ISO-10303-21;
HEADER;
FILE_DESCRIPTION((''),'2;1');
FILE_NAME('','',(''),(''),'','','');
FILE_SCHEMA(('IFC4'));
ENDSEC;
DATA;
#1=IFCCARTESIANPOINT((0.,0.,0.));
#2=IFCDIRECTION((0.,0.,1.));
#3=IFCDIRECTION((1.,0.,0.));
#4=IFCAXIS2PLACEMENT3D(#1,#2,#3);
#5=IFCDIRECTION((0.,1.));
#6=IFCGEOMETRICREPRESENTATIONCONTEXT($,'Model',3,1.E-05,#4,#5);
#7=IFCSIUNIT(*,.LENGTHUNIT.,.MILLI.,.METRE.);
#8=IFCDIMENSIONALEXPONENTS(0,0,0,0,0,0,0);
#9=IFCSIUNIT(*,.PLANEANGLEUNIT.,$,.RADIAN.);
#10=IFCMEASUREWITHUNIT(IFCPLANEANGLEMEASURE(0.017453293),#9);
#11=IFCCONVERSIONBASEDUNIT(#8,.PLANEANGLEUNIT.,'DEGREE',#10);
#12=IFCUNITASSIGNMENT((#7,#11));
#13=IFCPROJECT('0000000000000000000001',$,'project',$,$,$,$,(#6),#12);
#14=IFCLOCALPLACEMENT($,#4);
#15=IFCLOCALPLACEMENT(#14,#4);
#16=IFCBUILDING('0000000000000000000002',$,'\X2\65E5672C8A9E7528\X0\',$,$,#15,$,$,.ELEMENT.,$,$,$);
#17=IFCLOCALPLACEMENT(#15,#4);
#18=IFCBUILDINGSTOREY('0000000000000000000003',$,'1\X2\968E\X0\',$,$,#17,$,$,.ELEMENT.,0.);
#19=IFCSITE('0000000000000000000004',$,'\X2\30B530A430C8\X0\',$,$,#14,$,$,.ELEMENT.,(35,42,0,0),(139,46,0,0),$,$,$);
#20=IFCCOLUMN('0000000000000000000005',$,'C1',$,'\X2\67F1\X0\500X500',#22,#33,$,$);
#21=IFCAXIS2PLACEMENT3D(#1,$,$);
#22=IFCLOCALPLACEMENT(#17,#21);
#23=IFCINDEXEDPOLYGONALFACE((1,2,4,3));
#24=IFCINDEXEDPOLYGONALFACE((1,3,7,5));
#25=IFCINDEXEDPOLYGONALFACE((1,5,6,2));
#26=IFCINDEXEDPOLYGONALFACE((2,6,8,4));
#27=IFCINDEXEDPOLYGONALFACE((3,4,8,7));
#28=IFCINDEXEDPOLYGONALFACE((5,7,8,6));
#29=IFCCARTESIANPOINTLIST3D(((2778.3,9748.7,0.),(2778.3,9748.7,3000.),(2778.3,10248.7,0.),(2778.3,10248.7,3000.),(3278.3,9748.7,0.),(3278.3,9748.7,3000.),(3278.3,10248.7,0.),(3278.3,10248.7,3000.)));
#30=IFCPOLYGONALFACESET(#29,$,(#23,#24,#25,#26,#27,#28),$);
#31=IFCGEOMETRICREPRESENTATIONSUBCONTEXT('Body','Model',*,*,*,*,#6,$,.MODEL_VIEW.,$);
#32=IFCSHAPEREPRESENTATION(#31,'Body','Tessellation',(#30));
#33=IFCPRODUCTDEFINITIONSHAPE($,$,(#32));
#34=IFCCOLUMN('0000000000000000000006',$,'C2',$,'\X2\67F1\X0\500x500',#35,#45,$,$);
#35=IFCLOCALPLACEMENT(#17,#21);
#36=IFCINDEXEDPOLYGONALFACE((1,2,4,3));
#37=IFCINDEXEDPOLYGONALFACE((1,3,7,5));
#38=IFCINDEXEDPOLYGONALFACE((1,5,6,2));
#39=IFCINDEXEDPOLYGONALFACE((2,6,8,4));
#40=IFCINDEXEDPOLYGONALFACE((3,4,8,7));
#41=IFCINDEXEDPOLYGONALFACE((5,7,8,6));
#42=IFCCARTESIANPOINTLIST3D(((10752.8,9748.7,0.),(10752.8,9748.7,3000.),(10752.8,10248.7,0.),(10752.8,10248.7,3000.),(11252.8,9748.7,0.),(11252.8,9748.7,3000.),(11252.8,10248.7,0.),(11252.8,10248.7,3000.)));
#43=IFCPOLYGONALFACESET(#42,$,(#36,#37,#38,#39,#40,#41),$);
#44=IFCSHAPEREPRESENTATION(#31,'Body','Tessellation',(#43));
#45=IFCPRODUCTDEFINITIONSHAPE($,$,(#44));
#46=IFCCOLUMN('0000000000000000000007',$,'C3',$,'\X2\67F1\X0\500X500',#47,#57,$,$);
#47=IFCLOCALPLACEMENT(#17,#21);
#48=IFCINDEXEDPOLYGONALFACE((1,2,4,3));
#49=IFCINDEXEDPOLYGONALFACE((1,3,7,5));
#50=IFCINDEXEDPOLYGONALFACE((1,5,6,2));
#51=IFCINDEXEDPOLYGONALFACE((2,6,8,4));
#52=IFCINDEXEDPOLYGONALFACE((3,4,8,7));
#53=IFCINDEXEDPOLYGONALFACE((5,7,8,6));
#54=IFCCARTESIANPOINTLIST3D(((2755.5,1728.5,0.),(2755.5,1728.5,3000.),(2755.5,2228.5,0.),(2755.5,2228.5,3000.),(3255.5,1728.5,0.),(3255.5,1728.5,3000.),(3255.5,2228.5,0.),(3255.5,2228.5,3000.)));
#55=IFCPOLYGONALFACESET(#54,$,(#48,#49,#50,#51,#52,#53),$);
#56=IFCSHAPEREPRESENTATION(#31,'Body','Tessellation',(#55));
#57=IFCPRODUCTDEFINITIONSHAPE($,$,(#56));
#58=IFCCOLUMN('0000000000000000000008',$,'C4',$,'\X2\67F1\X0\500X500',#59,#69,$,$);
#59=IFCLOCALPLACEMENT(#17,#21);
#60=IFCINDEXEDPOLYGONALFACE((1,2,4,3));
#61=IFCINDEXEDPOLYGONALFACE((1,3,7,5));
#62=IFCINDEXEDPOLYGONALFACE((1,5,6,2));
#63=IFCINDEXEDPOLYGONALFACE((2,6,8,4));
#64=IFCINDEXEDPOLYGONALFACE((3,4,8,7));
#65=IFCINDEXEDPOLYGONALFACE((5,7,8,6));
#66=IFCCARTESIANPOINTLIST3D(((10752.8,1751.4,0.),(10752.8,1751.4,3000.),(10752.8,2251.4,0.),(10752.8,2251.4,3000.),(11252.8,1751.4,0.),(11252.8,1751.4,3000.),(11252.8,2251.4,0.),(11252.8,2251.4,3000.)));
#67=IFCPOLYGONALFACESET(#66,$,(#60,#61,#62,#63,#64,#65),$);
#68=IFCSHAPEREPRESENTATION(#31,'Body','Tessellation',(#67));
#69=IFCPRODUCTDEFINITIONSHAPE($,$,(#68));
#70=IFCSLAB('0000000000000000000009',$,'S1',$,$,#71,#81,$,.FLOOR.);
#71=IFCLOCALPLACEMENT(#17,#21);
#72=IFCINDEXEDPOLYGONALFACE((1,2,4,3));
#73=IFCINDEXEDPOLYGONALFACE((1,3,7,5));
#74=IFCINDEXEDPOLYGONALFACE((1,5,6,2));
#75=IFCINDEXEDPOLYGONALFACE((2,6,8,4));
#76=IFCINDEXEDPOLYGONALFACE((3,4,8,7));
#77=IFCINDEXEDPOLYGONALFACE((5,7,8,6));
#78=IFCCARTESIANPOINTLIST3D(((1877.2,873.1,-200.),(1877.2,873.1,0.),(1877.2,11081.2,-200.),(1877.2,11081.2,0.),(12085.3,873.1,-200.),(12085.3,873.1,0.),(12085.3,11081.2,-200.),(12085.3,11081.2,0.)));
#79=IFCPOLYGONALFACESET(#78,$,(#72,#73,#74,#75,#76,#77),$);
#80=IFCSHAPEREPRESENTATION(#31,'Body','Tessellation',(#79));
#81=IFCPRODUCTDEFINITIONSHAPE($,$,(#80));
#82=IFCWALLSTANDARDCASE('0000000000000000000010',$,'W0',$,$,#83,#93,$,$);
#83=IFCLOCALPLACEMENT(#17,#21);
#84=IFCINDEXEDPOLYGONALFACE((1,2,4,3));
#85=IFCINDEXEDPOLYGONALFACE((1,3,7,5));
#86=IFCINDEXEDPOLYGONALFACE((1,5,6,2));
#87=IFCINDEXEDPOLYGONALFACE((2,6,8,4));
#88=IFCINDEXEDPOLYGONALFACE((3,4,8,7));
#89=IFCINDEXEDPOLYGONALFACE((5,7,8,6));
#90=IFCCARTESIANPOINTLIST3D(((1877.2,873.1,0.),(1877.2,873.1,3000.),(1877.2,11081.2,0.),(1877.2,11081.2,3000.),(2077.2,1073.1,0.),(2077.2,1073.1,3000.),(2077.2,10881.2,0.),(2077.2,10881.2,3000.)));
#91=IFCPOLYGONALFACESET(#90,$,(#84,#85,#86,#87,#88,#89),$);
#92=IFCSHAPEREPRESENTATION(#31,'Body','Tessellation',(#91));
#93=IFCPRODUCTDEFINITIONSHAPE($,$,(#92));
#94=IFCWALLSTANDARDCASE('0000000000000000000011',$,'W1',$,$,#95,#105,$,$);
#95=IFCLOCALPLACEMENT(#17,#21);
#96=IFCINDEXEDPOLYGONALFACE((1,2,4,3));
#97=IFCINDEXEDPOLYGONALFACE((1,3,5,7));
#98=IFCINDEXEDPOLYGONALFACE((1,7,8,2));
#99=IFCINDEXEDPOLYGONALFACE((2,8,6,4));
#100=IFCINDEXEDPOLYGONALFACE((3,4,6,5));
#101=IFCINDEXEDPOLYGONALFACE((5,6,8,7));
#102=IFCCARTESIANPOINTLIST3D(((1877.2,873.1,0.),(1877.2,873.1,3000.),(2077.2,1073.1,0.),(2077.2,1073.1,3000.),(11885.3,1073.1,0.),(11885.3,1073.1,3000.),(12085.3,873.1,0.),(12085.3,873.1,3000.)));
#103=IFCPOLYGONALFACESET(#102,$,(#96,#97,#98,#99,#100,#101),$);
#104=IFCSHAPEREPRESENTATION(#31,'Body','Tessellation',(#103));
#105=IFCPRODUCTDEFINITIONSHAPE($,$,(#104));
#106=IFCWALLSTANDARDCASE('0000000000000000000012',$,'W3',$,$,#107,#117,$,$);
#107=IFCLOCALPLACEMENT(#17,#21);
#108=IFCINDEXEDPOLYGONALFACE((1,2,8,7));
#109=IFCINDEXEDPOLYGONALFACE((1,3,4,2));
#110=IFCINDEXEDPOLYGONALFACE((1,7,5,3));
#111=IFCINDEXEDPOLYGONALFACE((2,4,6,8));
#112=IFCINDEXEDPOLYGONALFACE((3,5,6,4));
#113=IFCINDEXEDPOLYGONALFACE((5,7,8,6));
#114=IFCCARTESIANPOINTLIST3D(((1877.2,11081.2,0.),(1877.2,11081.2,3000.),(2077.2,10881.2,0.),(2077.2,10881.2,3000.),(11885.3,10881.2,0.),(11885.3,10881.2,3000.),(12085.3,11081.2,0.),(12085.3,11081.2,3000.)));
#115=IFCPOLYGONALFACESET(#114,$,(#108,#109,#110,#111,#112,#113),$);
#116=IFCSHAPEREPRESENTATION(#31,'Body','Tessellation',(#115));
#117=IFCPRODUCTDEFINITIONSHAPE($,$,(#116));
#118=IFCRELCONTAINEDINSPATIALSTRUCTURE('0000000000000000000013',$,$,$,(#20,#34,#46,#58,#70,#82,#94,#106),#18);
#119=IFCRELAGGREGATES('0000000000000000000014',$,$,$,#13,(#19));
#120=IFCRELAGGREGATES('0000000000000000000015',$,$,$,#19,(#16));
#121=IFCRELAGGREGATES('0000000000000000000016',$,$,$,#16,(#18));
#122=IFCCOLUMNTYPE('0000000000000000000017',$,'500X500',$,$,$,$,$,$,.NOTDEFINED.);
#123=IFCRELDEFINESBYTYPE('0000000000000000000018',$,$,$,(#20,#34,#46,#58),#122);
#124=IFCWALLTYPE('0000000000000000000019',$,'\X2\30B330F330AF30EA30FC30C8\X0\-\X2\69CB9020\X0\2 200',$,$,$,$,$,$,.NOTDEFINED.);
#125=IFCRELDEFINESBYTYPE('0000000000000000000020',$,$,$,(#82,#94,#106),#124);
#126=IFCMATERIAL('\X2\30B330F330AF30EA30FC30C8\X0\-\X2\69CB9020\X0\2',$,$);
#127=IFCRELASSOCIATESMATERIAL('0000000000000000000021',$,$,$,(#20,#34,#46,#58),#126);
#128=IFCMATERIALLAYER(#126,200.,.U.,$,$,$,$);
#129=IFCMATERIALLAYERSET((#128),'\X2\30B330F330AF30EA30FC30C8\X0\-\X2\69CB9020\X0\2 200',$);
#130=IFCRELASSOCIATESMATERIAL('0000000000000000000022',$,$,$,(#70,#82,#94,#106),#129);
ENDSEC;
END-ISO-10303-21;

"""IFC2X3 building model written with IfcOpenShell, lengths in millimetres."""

from ifc_helpers import new_model, entity, si_unit, converted_unit, direction, frame, origin_with_axes, origin_2d_with_axis, place, context, subcontext, project, spatial, polyline, rectangle, outline, extrude, material, layer, layer_set, layer_usage, type_object, element, save


model = new_model("IFC2X3")

# Units and contexts
model_context = context("Model", 3, precision=1e-05, world=origin_with_axes(), true_north=direction((0.0, 1.0)))
body_context = subcontext(model_context, "Body", "Model", "MODEL_VIEW")
ifc_project = project(units=[si_unit("LENGTHUNIT", "METRE", prefix="MILLI"), converted_unit("PLANEANGLEUNIT", "DEGREE", entity("IfcPlaneAngleMeasure", 0.017453293), si_unit("PLANEANGLEUNIT", "RADIAN"), dimensions=[0, 0, 0, 0, 0, 0, 0])], contexts=[model_context])

# Site, building, storey
site_placement = place(None, origin_with_axes())
site = spatial("IfcSite", under=ifc_project, at=site_placement, Name="サイト", CompositionType="ELEMENT", RefLatitude=(35, 42, 0, 0), RefLongitude=(139, 46, 0, 0))
building_placement = place(site_placement, origin_with_axes())
building = spatial("IfcBuilding", under=site, at=building_placement, Name="日本語用", CompositionType="ELEMENT")
storey_placement = place(building_placement, origin_with_axes())
storey = spatial("IfcBuildingStorey", under=building, at=storey_placement, Name="1階", CompositionType="ELEMENT", Elevation=0.0)

# Columns
ifc_material = material(Name="コンクリート-構造2")
column_type = type_object("IfcColumnType", Name="500X500", PredefinedType="NOTDEFINED")
column_1_placement = place(storey_placement, frame((3028.3, 9998.7, 0.0), z_axis=(0.0, 0.0, 1.0), x_axis=(1.0, 0.0, 0.0)))
element("IfcColumn", 1, at=column_1_placement, inside=storey, type_object=column_type, material=ifc_material, Name="C1", ObjectType="柱500X500", context=body_context, shape_type="SweptSolid", body=[
    extrude(rectangle(XDim=500.0, YDim=500.0, at=origin_2d_with_axis()), origin_with_axes(), (0.0, 0.0, 1.0), 3000.0),
])
column_2_placement = place(storey_placement, frame((11002.8, 9998.7, 0.0), z_axis=(0.0, 0.0, 1.0), x_axis=(1.0, 0.0, 0.0)))
element("IfcColumn", 2, at=column_2_placement, inside=storey, type_object=column_type, material=ifc_material, Name="C2", ObjectType="柱500x500", context=body_context, shape_type="SweptSolid", body=[
    extrude(rectangle(XDim=500.0, YDim=500.0, at=origin_2d_with_axis()), origin_with_axes(), (0.0, 0.0, 1.0), 3000.0),
])
for number, where, z_axis, x_axis, name in (
    (3, (3005.5, 1978.5, 0.0), (0.0, 0.0, 1.0), (1.0, 0.0, 0.0), "C3"),
    (4, (11002.8, 2001.4, 0.0), (0.0, 0.0, 1.0), (1.0, 0.0, 0.0), "C4"),
):
    element("IfcColumn", number, at=place(storey_placement, frame(where, z_axis=z_axis, x_axis=x_axis)), inside=storey, type_object=column_type, material=ifc_material, Name=name, ObjectType="柱500X500", context=body_context, shape_type="SweptSolid", body=[
        extrude(rectangle(XDim=500.0, YDim=500.0, at=origin_2d_with_axis()), origin_with_axes(), (0.0, 0.0, 1.0), 3000.0),
    ])

# Slab
ifc_layer = layer(ifc_material, 200.0, ventilated="UNKNOWN")
ifc_layer_set = layer_set([ifc_layer], Name="コンクリート-構造2 200")
ifc_layer_usage_1 = layer_usage(ifc_layer_set, "AXIS3", "NEGATIVE", 200.0)
slab_placement = place(storey_placement, frame((1877.2, 11081.2, -200.0), z_axis=(0.0, 0.0, 1.0), x_axis=(1.0, 0.0, 0.0)))
element("IfcSlab", 5, at=slab_placement, inside=storey, material=ifc_layer_usage_1, Name="S1", PredefinedType="FLOOR", context=body_context, shape_type="SweptSolid", body=[
    extrude(outline(polyline([(0.0, 0.0), (0.0, -10208.1), (10208.1, -10208.1), (10208.1, 0.0), (0.0, 0.0)])), origin_with_axes(), (0.0, 0.0, 1.0), 200.0),
])

# Walls
ifc_layer_usage_2 = layer_usage(ifc_layer_set, "AXIS2", "NEGATIVE", 100.0)
wall_type = type_object("IfcWallType", Name="コンクリート-構造2 200", PredefinedType="NOTDEFINED")
wall_1_placement = place(storey_placement, frame((1977.2, 10981.2, 0.0), z_axis=(0.0, 0.0, 1.0), x_axis=(0.0, -1.0, 0.0)))
element("IfcWallStandardCase", 6, at=wall_1_placement, inside=storey, type_object=wall_type, material=ifc_layer_usage_2, Name="W0", context=body_context, shape_type="SweptSolid", body=[
    extrude(outline(polyline([(-100.0, -100.0), (10108.1, -100.0), (9908.1, 100.0), (100.0, 100.0), (-100.0, -100.0)])), origin_with_axes(), (0.0, 0.0, 1.0), 3000.0),
])
ifc_layer_usage_3 = layer_usage(ifc_layer_set, "AXIS2", "NEGATIVE", 100.0)
wall_2_placement = place(storey_placement, frame((1977.2, 973.1, 0.0), z_axis=(0.0, 0.0, 1.0), x_axis=(1.0, 0.0, 0.0)))
element("IfcWallStandardCase", 7, at=wall_2_placement, inside=storey, type_object=wall_type, material=ifc_layer_usage_3, Name="W1", context=body_context, shape_type="SweptSolid", body=[
    extrude(outline(polyline([(-100.0, -100.0), (10108.1, -100.0), (9908.1, 100.0), (100.0, 100.0), (-100.0, -100.0)])), origin_with_axes(), (0.0, 0.0, 1.0), 3000.0),
])

# Wall
ifc_layer_usage_4 = layer_usage(ifc_layer_set, "AXIS2", "NEGATIVE", 100.0)
wall_3_placement = place(storey_placement, frame((11985.3, 10981.2, 0.0), z_axis=(0.0, 0.0, 1.0), x_axis=(-1.0, 0.0, 0.0)))
element("IfcWallStandardCase", 8, at=wall_3_placement, inside=storey, type_object=wall_type, material=ifc_layer_usage_4, Name="W3", context=body_context, shape_type="SweptSolid", body=[
    extrude(outline(polyline([(-100.0, -100.0), (10108.1, -100.0), (9908.1, 100.0), (100.0, 100.0), (-100.0, -100.0)])), origin_with_axes(), (0.0, 0.0, 1.0), 3000.0),
])

save(model, "model.ifc")
